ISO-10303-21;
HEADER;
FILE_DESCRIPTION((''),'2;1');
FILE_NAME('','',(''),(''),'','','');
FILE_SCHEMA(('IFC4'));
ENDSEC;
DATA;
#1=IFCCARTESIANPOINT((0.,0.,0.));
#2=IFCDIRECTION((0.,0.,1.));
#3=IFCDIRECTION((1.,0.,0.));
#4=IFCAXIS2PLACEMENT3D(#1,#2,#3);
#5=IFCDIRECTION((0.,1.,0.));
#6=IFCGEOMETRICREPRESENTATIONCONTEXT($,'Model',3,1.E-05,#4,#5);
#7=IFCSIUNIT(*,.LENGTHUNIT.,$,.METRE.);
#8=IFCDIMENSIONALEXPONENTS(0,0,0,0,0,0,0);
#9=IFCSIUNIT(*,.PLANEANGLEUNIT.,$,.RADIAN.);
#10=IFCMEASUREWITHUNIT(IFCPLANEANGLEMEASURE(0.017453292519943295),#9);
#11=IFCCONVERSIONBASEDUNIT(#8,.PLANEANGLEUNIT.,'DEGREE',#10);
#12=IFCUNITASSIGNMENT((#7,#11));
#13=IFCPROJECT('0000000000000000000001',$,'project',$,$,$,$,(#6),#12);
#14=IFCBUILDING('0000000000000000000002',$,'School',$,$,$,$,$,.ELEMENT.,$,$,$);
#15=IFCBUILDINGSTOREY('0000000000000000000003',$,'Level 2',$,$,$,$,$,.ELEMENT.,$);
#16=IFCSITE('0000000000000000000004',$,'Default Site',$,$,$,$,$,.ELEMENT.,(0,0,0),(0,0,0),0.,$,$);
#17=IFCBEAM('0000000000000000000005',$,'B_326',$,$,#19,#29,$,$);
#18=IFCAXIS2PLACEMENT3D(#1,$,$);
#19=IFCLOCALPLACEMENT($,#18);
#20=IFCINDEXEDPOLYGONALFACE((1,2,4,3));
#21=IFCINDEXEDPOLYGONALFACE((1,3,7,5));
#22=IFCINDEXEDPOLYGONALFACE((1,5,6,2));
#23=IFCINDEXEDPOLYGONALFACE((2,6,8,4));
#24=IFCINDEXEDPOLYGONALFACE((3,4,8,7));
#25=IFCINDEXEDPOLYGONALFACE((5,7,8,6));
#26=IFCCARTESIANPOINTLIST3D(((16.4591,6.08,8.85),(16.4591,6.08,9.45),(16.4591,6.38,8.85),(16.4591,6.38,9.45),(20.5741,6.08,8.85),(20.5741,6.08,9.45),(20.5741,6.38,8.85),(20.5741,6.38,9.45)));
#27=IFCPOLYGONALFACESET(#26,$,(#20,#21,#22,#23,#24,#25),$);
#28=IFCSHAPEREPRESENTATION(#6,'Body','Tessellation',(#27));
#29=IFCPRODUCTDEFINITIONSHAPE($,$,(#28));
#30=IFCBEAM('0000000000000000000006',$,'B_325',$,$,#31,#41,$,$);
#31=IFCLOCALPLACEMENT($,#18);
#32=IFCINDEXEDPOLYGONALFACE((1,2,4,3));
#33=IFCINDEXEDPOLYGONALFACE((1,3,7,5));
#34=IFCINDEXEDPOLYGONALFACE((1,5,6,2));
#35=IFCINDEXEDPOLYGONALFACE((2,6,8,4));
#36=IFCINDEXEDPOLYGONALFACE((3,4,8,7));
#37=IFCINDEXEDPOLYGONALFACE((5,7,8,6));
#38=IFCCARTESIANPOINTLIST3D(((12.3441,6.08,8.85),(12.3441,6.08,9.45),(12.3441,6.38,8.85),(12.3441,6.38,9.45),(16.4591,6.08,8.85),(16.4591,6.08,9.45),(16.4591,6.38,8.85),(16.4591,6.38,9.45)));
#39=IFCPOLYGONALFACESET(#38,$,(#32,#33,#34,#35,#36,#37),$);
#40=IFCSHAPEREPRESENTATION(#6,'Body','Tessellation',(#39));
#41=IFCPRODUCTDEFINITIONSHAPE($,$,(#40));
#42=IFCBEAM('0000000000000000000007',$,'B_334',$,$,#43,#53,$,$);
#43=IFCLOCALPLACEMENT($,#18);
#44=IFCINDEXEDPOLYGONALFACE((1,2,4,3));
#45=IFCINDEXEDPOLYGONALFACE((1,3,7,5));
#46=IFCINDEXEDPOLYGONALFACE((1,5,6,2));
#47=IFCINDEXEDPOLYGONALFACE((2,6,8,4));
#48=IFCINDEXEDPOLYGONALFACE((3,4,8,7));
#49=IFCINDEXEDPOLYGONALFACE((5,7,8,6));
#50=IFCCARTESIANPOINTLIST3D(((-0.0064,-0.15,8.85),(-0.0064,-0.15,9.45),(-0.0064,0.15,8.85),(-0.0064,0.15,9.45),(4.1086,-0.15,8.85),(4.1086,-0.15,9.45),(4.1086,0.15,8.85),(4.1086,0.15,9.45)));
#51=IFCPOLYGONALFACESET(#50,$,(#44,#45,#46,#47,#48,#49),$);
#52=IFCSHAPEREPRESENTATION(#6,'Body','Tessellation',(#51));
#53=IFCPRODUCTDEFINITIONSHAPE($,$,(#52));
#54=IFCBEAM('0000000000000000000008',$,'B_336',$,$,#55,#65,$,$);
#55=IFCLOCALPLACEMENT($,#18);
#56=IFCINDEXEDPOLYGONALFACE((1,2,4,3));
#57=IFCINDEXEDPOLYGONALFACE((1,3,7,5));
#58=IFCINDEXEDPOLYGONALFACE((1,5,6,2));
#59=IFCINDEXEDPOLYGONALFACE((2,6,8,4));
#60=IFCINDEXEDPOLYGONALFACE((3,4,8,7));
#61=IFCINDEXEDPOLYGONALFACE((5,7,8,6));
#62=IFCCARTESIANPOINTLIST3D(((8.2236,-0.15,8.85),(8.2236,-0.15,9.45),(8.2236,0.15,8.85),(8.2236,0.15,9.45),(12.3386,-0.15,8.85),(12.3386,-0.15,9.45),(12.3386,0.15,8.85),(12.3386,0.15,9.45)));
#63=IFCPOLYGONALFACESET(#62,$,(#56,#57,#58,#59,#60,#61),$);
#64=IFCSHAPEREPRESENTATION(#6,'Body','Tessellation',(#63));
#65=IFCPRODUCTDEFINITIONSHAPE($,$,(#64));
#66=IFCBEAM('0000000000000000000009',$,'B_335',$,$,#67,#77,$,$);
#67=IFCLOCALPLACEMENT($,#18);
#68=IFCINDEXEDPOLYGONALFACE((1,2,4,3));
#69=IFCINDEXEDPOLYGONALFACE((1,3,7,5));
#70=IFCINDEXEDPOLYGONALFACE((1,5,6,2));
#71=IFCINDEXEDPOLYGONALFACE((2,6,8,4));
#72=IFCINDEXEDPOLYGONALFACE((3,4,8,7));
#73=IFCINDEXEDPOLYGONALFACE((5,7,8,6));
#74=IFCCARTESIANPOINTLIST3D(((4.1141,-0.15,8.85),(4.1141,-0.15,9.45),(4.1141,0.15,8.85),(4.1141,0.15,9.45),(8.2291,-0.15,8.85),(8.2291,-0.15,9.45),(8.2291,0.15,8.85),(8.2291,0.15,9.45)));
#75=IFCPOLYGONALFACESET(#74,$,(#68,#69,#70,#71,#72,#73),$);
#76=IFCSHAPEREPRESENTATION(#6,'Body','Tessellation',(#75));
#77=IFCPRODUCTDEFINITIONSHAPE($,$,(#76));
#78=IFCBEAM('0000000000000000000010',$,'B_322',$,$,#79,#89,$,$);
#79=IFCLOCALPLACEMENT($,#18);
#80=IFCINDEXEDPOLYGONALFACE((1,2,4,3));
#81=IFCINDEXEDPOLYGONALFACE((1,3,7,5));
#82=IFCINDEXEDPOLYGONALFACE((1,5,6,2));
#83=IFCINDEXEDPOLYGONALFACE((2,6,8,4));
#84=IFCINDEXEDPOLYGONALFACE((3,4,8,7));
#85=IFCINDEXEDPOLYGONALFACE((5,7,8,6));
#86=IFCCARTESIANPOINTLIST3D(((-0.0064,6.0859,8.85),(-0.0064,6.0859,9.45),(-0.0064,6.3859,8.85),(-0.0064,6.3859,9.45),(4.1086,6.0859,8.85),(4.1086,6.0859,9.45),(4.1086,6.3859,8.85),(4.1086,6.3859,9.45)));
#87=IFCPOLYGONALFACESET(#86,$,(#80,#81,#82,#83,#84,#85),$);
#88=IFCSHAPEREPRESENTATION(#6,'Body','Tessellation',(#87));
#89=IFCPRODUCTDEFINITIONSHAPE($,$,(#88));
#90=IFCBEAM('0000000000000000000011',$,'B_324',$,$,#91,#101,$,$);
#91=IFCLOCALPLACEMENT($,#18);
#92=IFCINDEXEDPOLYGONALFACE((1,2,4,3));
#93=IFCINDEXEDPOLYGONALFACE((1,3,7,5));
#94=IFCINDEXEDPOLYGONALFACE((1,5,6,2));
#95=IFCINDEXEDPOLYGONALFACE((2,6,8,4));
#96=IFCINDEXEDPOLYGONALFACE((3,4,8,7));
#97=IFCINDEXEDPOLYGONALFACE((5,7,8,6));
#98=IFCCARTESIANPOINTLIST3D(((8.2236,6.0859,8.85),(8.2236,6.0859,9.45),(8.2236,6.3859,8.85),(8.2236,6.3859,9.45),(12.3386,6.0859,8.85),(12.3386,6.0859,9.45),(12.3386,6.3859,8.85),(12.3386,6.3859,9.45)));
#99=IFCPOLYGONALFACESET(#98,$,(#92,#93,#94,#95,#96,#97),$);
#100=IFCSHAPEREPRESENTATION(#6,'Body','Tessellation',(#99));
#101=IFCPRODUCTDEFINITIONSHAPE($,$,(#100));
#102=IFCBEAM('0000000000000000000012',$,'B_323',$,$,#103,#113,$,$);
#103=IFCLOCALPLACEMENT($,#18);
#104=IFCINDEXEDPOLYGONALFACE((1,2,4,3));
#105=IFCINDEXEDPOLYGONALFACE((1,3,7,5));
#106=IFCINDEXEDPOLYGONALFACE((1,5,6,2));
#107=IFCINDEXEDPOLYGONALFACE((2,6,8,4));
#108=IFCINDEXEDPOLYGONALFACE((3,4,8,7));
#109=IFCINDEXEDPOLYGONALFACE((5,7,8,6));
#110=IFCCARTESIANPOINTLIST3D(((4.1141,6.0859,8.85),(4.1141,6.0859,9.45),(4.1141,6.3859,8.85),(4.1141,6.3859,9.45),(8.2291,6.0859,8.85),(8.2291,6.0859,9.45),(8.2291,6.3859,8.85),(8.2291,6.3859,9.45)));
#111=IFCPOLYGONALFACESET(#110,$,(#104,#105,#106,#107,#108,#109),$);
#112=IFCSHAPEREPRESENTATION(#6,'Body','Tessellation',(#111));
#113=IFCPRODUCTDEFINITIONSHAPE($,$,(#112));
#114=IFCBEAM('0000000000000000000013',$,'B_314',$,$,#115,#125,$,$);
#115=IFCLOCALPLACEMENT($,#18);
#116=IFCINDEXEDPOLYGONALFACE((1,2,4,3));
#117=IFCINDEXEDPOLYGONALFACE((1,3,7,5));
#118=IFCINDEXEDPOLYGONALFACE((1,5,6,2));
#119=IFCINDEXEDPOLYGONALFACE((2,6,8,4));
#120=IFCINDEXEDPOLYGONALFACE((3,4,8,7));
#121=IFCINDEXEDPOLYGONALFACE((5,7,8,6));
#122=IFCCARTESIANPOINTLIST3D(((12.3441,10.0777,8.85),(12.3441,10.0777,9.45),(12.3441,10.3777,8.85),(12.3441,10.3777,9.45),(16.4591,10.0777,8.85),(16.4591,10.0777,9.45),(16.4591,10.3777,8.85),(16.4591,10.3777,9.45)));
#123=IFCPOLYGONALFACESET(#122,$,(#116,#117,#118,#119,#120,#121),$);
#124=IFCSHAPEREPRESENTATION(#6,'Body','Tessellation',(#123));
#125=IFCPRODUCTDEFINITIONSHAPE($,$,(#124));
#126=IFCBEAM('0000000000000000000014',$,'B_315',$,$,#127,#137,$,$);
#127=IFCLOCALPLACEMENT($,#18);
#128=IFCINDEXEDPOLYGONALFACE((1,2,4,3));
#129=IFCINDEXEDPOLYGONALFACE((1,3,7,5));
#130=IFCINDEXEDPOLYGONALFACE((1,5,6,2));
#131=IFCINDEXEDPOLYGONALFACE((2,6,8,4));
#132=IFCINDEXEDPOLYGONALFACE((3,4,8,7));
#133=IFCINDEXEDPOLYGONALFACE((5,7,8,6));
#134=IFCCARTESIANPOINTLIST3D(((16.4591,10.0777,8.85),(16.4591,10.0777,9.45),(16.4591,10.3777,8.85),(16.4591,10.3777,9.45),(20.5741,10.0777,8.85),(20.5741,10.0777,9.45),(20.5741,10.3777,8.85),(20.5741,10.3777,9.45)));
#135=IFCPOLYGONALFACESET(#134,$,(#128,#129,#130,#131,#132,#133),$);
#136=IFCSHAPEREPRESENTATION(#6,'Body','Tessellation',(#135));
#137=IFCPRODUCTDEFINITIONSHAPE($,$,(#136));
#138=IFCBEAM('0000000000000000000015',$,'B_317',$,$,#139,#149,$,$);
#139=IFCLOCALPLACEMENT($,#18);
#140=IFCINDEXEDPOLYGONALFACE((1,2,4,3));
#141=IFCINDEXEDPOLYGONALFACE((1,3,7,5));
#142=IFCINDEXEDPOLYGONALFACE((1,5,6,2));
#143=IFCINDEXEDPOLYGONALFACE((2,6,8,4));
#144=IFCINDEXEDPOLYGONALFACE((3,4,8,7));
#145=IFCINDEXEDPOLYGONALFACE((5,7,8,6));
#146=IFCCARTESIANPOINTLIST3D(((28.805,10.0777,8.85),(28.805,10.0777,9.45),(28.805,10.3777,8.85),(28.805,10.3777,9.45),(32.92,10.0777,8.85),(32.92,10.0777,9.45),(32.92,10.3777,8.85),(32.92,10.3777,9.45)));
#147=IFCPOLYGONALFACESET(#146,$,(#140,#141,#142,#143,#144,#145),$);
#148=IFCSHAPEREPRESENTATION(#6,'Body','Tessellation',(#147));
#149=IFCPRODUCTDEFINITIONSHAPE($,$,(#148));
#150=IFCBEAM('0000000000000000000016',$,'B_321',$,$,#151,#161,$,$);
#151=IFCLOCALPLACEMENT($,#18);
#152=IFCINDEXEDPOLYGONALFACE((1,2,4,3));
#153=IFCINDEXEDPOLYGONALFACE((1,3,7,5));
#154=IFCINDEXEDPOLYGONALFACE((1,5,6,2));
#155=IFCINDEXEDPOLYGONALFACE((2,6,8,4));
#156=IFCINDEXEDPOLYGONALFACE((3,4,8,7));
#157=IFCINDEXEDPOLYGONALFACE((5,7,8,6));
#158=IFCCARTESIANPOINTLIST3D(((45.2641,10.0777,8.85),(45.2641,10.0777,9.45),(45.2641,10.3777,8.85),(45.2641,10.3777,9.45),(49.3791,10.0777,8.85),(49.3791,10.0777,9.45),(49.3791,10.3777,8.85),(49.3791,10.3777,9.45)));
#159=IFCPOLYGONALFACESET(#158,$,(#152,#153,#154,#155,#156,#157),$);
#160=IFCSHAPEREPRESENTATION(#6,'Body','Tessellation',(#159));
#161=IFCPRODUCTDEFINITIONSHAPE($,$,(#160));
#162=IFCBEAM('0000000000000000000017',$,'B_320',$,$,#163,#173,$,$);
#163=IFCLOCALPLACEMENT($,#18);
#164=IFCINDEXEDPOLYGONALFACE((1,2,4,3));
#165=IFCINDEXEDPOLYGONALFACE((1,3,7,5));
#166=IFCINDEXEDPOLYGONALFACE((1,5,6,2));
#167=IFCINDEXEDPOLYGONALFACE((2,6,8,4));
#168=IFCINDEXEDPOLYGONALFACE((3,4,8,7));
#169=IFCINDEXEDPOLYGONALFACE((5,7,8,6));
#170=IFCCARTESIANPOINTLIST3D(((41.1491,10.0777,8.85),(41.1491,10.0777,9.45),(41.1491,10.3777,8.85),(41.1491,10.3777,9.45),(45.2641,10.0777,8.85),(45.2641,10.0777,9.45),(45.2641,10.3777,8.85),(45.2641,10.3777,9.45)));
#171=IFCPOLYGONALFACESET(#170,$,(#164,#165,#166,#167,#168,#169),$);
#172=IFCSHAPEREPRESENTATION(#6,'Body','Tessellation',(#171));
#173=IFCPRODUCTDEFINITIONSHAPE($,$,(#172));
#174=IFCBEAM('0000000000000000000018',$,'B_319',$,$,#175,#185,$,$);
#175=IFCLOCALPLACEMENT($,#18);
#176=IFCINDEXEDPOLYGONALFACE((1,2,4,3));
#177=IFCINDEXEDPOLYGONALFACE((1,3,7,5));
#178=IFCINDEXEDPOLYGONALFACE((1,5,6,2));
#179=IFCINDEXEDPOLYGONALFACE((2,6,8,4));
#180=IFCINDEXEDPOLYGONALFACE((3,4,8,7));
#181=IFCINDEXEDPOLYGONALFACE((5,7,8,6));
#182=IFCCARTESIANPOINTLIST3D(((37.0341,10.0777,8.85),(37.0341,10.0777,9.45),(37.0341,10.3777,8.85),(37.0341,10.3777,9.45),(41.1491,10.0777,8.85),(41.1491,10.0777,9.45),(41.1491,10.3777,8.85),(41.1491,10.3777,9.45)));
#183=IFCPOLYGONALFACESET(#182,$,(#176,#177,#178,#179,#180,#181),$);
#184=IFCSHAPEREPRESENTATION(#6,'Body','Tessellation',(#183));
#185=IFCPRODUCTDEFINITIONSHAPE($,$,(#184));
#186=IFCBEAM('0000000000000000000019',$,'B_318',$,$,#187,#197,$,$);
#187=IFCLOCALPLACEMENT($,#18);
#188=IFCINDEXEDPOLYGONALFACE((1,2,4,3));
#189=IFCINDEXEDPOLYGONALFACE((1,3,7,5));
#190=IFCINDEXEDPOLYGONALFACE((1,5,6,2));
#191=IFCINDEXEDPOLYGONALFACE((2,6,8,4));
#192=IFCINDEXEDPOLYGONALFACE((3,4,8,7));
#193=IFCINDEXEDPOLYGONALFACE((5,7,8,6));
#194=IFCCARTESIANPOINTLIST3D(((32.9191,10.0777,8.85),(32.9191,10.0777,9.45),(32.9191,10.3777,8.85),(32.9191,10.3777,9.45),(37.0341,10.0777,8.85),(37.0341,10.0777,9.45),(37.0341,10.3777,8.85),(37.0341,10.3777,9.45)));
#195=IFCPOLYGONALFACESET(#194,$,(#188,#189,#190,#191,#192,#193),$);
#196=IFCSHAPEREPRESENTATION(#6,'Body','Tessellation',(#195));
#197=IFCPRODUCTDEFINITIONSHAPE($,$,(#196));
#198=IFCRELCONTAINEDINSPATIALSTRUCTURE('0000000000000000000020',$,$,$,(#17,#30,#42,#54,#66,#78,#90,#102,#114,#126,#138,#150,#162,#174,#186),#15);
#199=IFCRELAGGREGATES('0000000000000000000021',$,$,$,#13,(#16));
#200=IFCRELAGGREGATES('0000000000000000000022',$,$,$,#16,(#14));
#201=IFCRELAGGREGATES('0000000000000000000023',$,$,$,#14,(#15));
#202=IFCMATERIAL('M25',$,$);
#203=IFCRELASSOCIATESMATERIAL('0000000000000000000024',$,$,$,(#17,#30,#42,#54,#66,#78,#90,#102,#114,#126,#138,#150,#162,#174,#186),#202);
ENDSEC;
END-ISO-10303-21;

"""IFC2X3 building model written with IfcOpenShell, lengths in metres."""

from ifc_helpers import new_model, entity, si_unit, converted_unit, direction, frame, frame_2d, origin_with_axes, place, context, project, spatial, rectangle, extrude, material, element, save


model = new_model("IFC2X3")

# Units and contexts
model_context = context("Model", 3, precision=1e-05, world=origin_with_axes(), true_north=direction((0.0, 1.0, 0.0)))
ifc_project = project(units=[si_unit("LENGTHUNIT", "METRE"), converted_unit("PLANEANGLEUNIT", "DEGREE", entity("IfcPlaneAngleMeasure", 0.017453292519943295), si_unit("PLANEANGLEUNIT", "RADIAN"), dimensions=[0, 0, 0, 0, 0, 0, 0])], contexts=[model_context])

# Site, building, storey
site = spatial("IfcSite", under=ifc_project, Name="Default Site", CompositionType="ELEMENT", RefLatitude=(0, 0, 0), RefLongitude=(0, 0, 0), RefElevation=0.0)
building = spatial("IfcBuilding", under=site, Name="School", CompositionType="ELEMENT")
storey = spatial("IfcBuildingStorey", under=building, Name="Level 2", CompositionType="ELEMENT")

# Beams
ifc_material = material(Name="M25")
placement = place(None, origin_with_axes())
element("IfcBeam", 1, at=placement, inside=storey, material=ifc_material, Name="B_326", context=model_context, shape_type="SweptSolid", body=[
    extrude(rectangle(XDim=0.3, YDim=0.6, at=frame_2d((0.0, 0.0), x_axis=(0.0, 1.0, 0.0))), frame((16.4591, 6.23, 9.15), z_axis=(1.0, 0.0, 0.0), x_axis=(0.0, 0.0, -1.0)), (0.0, 0.0, 1.0), 4.115),
])
element("IfcBeam", 2, at=placement, inside=storey, material=ifc_material, Name="B_325", context=model_context, shape_type="SweptSolid", body=[
    extrude(rectangle(XDim=0.3, YDim=0.6, at=frame_2d((0.0, 0.0), x_axis=(0.0, 1.0, 0.0))), frame((12.3441, 6.23, 9.15), z_axis=(1.0, 0.0, 0.0), x_axis=(0.0, 0.0, -1.0)), (0.0, 0.0, 1.0), 4.115),
])
element("IfcBeam", 3, at=placement, inside=storey, material=ifc_material, Name="B_334", context=model_context, shape_type="SweptSolid", body=[
    extrude(rectangle(XDim=0.3, YDim=0.6, at=frame_2d((0.0, 0.0), x_axis=(0.0, 1.0, 0.0))), frame((-0.0064, 0.0, 9.15), z_axis=(1.0, 0.0, 0.0), x_axis=(0.0, 0.0, -1.0)), (0.0, 0.0, 1.0), 4.115),
])
element("IfcBeam", 4, at=placement, inside=storey, material=ifc_material, Name="B_336", context=model_context, shape_type="SweptSolid", body=[
    extrude(rectangle(XDim=0.3, YDim=0.6, at=frame_2d((0.0, 0.0), x_axis=(0.0, 1.0, 0.0))), frame((8.2236, 0.0, 9.15), z_axis=(1.0, 0.0, 0.0), x_axis=(0.0, 0.0, -1.0)), (0.0, 0.0, 1.0), 4.115),
])
element("IfcBeam", 5, at=placement, inside=storey, material=ifc_material, Name="B_335", context=model_context, shape_type="SweptSolid", body=[
    extrude(rectangle(XDim=0.3, YDim=0.6, at=frame_2d((0.0, 0.0), x_axis=(0.0, 1.0, 0.0))), frame((4.1141, 0.0, 9.15), z_axis=(1.0, 0.0, 0.0), x_axis=(0.0, 0.0, -1.0)), (0.0, 0.0, 1.0), 4.115),
])
element("IfcBeam", 6, at=placement, inside=storey, material=ifc_material, Name="B_322", context=model_context, shape_type="SweptSolid", body=[
    extrude(rectangle(XDim=0.3, YDim=0.6, at=frame_2d((0.0, 0.0), x_axis=(0.0, 1.0, 0.0))), frame((-0.0064, 6.2359, 9.15), z_axis=(1.0, 0.0, 0.0), x_axis=(0.0, 0.0, -1.0)), (0.0, 0.0, 1.0), 4.115),
])
element("IfcBeam", 7, at=placement, inside=storey, material=ifc_material, Name="B_324", context=model_context, shape_type="SweptSolid", body=[
    extrude(rectangle(XDim=0.3, YDim=0.6, at=frame_2d((0.0, 0.0), x_axis=(0.0, 1.0, 0.0))), frame((8.2236, 6.2359, 9.15), z_axis=(1.0, 0.0, 0.0), x_axis=(0.0, 0.0, -1.0)), (0.0, 0.0, 1.0), 4.115),
])
element("IfcBeam", 8, at=placement, inside=storey, material=ifc_material, Name="B_323", context=model_context, shape_type="SweptSolid", body=[
    extrude(rectangle(XDim=0.3, YDim=0.6, at=frame_2d((0.0, 0.0), x_axis=(0.0, 1.0, 0.0))), frame((4.1141, 6.2359, 9.15), z_axis=(1.0, 0.0, 0.0), x_axis=(0.0, 0.0, -1.0)), (0.0, 0.0, 1.0), 4.115),
])
element("IfcBeam", 9, at=placement, inside=storey, material=ifc_material, Name="B_314", context=model_context, shape_type="SweptSolid", body=[
    extrude(rectangle(XDim=0.3, YDim=0.6, at=frame_2d((0.0, 0.0), x_axis=(0.0, 1.0, 0.0))), frame((12.3441, 10.2277, 9.15), z_axis=(1.0, 0.0, 0.0), x_axis=(0.0, 0.0, -1.0)), (0.0, 0.0, 1.0), 4.115),
])
element("IfcBeam", 10, at=placement, inside=storey, material=ifc_material, Name="B_315", context=model_context, shape_type="SweptSolid", body=[
    extrude(rectangle(XDim=0.3, YDim=0.6, at=frame_2d((0.0, 0.0), x_axis=(0.0, 1.0, 0.0))), frame((16.4591, 10.2277, 9.15), z_axis=(1.0, 0.0, 0.0), x_axis=(0.0, 0.0, -1.0)), (0.0, 0.0, 1.0), 4.115),
])
element("IfcBeam", 11, at=placement, inside=storey, material=ifc_material, Name="B_317", context=model_context, shape_type="SweptSolid", body=[
    extrude(rectangle(XDim=0.3, YDim=0.6, at=frame_2d((0.0, 0.0), x_axis=(0.0, 1.0, 0.0))), frame((28.805, 10.2277, 9.15), z_axis=(1.0, 0.0, 0.0), x_axis=(0.0, 0.0, -1.0)), (0.0, 0.0, 1.0), 4.115),
])
element("IfcBeam", 12, at=placement, inside=storey, material=ifc_material, Name="B_321", context=model_context, shape_type="SweptSolid", body=[
    extrude(rectangle(XDim=0.3, YDim=0.6, at=frame_2d((0.0, 0.0), x_axis=(0.0, 1.0, 0.0))), frame((45.2641, 10.2277, 9.15), z_axis=(1.0, 0.0, 0.0), x_axis=(0.0, 0.0, -1.0)), (0.0, 0.0, 1.0), 4.115),
])
element("IfcBeam", 13, at=placement, inside=storey, material=ifc_material, Name="B_320", context=model_context, shape_type="SweptSolid", body=[
    extrude(rectangle(XDim=0.3, YDim=0.6, at=frame_2d((0.0, 0.0), x_axis=(0.0, 1.0, 0.0))), frame((41.1491, 10.2277, 9.15), z_axis=(1.0, 0.0, 0.0), x_axis=(0.0, 0.0, -1.0)), (0.0, 0.0, 1.0), 4.115),
])
element("IfcBeam", 14, at=placement, inside=storey, material=ifc_material, Name="B_319", context=model_context, shape_type="SweptSolid", body=[
    extrude(rectangle(XDim=0.3, YDim=0.6, at=frame_2d((0.0, 0.0), x_axis=(0.0, 1.0, 0.0))), frame((37.0341, 10.2277, 9.15), z_axis=(1.0, 0.0, 0.0), x_axis=(0.0, 0.0, -1.0)), (0.0, 0.0, 1.0), 4.115),
])
element("IfcBeam", 15, at=placement, inside=storey, material=ifc_material, Name="B_318", context=model_context, shape_type="SweptSolid", body=[
    extrude(rectangle(XDim=0.3, YDim=0.6, at=frame_2d((0.0, 0.0), x_axis=(0.0, 1.0, 0.0))), frame((32.9191, 10.2277, 9.15), z_axis=(1.0, 0.0, 0.0), x_axis=(0.0, 0.0, -1.0)), (0.0, 0.0, 1.0), 4.115),
])

save(model, "model.ifc")
